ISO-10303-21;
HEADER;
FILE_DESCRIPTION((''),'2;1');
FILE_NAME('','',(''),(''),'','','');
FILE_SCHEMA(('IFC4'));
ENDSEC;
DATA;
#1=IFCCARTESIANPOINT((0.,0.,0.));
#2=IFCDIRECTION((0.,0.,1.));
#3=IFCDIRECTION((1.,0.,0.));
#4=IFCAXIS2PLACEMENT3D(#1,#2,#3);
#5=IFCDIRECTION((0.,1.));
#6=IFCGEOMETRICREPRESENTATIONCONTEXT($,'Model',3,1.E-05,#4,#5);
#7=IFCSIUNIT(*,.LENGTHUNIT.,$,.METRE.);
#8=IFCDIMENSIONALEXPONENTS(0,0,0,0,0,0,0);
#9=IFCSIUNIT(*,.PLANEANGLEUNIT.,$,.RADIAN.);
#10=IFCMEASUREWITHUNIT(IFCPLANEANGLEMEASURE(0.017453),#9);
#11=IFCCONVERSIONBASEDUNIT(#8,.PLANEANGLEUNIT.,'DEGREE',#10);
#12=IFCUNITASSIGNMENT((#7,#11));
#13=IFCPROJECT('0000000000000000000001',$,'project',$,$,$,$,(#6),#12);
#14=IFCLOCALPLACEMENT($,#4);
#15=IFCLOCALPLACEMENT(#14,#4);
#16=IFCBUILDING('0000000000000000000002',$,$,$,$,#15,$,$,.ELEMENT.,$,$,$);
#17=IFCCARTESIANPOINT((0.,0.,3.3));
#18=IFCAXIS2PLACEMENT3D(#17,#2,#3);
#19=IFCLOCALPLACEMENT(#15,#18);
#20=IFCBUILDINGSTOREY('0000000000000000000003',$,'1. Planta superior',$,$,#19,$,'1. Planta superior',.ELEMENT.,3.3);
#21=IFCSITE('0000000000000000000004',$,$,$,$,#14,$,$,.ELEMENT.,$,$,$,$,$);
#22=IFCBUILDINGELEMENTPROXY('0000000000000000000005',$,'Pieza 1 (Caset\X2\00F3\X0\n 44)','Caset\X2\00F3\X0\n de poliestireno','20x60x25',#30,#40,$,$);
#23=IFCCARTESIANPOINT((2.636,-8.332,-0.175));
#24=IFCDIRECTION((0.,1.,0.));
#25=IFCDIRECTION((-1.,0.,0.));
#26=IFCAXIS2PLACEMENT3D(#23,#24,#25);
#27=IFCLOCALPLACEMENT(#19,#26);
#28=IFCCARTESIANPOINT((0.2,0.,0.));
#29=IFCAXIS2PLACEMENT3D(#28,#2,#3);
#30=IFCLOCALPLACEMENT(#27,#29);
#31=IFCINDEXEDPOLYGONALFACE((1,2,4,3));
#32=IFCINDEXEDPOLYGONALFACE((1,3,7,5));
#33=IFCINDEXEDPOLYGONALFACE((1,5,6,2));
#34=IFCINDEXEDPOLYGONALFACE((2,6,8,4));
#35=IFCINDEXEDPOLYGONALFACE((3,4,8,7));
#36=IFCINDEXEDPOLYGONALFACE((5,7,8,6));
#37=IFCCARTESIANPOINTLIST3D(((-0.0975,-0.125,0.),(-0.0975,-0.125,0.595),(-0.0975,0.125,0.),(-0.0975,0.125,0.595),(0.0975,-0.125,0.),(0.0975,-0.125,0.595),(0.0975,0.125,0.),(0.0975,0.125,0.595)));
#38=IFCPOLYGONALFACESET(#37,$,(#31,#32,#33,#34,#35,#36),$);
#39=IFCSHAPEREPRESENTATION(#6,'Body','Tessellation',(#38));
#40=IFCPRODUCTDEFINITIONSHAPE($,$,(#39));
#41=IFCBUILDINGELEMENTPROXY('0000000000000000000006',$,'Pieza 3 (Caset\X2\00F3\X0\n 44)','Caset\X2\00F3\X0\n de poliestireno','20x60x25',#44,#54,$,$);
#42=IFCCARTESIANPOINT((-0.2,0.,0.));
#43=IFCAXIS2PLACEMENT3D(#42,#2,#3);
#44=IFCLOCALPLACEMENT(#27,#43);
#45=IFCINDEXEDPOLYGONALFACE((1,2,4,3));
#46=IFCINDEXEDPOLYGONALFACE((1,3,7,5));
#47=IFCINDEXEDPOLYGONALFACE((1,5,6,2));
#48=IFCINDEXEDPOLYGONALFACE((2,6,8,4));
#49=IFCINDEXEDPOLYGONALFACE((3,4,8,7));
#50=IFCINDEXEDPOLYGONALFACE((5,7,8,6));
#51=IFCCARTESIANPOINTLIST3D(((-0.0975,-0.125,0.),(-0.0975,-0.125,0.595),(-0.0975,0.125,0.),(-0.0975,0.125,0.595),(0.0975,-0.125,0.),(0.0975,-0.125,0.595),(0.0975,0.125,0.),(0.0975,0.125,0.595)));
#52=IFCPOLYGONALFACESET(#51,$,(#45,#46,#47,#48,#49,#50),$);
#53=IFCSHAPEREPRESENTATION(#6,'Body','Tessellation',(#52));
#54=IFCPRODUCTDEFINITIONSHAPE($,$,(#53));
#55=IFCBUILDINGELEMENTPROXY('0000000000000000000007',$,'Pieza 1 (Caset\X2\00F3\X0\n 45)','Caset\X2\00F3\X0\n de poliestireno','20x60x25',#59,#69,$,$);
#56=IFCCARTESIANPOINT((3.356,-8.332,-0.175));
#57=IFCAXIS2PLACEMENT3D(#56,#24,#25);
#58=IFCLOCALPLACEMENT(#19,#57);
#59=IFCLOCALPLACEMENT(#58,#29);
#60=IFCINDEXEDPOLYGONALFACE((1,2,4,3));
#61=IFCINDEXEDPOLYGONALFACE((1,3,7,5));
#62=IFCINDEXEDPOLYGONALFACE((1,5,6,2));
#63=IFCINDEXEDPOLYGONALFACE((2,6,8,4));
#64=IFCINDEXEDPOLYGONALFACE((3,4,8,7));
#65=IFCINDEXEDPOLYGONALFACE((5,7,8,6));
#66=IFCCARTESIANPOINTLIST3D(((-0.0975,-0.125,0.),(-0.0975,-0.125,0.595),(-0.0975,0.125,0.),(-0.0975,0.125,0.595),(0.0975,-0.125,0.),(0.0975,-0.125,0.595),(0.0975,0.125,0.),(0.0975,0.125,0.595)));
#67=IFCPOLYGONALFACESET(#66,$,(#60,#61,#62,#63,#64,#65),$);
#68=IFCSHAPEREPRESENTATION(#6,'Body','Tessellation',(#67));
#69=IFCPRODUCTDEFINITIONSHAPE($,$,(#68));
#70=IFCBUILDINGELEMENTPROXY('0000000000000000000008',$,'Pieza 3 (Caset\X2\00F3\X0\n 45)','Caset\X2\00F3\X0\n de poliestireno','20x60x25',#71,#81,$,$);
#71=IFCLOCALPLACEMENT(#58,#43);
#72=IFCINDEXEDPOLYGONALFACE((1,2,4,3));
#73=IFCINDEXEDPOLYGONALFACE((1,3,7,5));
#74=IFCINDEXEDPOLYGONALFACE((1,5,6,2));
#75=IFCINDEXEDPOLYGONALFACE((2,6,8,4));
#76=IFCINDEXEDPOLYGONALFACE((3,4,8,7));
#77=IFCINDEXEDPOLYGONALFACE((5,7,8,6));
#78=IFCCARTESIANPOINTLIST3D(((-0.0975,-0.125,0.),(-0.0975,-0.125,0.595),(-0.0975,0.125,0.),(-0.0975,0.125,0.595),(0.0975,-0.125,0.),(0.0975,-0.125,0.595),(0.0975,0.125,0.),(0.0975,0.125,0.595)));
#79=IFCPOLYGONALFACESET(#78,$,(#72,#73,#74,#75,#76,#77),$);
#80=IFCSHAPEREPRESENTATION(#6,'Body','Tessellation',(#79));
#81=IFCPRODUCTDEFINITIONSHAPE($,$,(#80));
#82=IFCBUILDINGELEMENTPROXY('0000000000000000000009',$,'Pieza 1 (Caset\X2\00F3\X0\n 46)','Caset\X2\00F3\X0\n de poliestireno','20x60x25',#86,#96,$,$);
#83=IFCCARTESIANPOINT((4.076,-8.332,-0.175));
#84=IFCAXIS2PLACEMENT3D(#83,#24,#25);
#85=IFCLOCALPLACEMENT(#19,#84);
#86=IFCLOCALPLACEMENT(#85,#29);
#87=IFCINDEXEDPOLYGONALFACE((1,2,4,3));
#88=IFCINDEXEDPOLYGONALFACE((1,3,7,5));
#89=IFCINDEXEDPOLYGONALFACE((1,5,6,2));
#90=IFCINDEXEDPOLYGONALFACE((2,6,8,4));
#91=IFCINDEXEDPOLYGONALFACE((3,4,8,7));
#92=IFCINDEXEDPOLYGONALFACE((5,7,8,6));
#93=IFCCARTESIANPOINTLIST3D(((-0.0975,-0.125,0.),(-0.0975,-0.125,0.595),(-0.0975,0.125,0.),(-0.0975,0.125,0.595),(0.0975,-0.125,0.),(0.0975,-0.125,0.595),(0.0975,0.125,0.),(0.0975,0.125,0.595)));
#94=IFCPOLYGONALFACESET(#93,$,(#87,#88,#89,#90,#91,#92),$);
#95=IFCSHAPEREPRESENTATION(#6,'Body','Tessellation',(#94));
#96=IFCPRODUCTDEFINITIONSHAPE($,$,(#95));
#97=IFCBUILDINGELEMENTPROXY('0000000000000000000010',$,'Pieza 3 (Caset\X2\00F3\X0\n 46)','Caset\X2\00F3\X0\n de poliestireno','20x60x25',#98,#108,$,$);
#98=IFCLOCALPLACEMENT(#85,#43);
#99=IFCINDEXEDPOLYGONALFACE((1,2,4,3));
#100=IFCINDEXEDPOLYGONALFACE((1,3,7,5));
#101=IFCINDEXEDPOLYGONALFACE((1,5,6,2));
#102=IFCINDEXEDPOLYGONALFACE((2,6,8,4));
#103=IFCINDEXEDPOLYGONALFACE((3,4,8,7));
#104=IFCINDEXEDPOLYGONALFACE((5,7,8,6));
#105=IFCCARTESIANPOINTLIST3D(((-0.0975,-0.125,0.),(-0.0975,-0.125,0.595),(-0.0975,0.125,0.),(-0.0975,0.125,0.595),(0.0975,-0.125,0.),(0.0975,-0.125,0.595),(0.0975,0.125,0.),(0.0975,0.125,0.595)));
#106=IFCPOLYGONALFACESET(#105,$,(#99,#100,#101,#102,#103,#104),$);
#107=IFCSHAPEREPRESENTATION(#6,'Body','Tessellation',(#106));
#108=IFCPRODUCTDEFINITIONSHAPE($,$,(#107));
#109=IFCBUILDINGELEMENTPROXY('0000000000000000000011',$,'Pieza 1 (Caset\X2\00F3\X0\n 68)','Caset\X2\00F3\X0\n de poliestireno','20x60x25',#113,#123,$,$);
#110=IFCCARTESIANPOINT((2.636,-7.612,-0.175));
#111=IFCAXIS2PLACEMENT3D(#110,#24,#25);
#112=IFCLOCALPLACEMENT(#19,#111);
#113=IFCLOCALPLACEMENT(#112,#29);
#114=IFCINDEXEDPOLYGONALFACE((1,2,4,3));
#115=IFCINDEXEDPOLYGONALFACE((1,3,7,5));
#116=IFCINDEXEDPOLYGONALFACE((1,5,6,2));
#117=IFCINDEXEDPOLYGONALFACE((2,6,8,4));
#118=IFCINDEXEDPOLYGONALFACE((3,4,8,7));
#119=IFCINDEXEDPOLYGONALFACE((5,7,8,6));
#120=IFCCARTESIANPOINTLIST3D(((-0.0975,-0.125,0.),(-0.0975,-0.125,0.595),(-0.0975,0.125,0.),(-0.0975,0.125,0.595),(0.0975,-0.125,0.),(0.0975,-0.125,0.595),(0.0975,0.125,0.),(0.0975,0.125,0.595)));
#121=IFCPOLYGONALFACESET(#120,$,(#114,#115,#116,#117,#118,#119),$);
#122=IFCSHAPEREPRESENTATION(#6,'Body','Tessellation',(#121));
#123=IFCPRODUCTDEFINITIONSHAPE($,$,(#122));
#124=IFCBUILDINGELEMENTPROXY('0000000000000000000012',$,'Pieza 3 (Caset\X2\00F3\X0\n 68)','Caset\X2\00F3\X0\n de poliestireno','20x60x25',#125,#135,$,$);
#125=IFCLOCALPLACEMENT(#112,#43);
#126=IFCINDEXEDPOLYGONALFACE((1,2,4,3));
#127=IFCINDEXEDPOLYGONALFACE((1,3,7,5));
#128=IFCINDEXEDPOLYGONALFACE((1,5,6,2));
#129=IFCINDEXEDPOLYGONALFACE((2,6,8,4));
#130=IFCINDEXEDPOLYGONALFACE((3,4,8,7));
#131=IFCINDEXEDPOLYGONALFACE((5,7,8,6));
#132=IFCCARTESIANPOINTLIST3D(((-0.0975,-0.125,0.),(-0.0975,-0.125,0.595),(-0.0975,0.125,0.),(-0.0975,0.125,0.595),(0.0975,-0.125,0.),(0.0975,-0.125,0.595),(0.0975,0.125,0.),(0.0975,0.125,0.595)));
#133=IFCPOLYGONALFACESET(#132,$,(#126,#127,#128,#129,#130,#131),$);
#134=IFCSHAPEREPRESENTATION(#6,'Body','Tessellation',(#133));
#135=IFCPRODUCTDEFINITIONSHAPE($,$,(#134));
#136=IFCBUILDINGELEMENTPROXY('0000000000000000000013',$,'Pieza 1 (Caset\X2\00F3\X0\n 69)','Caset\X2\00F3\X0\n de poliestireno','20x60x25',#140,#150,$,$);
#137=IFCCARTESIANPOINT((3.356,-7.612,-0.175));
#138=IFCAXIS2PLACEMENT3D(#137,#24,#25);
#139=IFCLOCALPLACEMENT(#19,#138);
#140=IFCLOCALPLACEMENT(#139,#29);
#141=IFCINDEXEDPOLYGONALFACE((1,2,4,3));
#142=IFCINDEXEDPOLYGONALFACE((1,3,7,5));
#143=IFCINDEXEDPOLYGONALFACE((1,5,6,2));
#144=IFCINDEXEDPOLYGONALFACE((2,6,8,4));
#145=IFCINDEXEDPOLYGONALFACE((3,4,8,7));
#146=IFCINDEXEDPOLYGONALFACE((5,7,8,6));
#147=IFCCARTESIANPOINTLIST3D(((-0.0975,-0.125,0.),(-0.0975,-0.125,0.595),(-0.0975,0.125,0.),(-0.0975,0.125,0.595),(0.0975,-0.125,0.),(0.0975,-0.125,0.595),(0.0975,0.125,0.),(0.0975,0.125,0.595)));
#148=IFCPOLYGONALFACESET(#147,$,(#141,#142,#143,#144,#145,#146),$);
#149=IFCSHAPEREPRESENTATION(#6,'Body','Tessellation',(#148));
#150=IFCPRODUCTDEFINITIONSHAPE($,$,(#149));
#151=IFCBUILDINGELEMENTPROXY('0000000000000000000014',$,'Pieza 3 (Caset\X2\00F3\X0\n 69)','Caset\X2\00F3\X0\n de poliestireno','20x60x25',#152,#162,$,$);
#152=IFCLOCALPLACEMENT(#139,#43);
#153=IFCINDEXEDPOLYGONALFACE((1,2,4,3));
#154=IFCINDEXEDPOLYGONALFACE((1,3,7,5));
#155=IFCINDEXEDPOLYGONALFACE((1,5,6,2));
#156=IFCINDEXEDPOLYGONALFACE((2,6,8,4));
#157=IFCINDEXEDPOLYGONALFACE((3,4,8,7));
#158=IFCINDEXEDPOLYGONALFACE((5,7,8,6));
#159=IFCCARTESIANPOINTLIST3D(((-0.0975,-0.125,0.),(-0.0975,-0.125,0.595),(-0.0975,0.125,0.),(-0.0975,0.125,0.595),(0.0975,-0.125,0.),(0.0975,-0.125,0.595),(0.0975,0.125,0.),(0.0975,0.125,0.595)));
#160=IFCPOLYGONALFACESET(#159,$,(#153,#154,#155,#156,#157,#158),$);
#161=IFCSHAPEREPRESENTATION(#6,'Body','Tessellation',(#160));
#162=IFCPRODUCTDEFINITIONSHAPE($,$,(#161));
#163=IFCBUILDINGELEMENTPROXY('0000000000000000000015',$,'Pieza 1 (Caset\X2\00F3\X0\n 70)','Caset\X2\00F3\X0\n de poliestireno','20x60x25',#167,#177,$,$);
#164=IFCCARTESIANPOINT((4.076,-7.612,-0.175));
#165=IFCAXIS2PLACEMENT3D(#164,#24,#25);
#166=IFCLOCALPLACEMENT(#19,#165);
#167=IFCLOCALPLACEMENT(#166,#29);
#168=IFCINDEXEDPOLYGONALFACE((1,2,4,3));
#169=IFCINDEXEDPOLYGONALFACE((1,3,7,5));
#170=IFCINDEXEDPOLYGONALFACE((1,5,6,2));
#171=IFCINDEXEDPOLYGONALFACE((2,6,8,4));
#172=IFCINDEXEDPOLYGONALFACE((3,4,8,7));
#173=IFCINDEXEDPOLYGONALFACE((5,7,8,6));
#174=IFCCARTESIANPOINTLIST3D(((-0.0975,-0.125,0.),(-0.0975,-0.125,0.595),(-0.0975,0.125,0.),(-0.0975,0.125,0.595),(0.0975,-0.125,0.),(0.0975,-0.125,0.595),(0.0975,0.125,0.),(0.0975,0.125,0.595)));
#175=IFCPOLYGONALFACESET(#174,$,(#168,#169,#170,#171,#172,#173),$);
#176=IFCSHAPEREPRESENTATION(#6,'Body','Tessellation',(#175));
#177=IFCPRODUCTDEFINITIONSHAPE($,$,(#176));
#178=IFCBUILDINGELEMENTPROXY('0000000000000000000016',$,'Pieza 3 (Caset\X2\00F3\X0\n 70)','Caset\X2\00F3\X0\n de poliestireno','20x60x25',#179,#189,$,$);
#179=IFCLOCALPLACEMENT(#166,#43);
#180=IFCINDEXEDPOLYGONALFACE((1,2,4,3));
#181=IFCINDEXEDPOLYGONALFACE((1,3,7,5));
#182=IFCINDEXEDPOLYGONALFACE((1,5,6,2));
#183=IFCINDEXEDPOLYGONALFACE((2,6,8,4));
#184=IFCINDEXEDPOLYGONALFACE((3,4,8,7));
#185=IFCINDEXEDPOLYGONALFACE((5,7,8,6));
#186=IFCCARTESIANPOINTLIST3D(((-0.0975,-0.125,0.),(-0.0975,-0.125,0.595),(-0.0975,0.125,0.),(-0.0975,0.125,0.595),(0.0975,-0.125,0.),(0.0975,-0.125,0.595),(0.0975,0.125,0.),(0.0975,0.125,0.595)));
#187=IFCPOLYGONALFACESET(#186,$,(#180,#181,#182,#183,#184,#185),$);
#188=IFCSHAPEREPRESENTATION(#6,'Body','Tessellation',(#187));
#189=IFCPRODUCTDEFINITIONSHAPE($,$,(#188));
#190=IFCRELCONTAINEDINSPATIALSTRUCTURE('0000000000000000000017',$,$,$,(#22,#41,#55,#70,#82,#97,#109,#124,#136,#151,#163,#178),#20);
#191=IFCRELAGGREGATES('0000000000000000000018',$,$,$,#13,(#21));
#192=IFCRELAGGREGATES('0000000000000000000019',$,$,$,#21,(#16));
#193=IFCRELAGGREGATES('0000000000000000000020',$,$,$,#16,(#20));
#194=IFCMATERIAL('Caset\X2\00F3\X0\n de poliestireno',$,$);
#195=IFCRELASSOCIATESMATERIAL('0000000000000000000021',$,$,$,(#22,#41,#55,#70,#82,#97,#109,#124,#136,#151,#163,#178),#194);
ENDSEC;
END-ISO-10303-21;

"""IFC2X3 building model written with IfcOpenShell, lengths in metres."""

from ifc_helpers import new_model, entity, si_unit, converted_unit, direction, frame, origin_with_axes, origin_2d_with_axis, place, context, project, spatial, rectangle, extrude, source, transform, mapped, material, element, save


model = new_model("IFC2X3")

# Units and contexts
model_context = context("Model", 3, precision=1e-05, world=origin_with_axes(), true_north=direction((0.0, 1.0)))
ifc_project = project(units=[si_unit("LENGTHUNIT", "METRE"), converted_unit("PLANEANGLEUNIT", "DEGREE", entity("IfcPlaneAngleMeasure", 0.017453), si_unit("PLANEANGLEUNIT", "RADIAN"), dimensions=[0, 0, 0, 0, 0, 0, 0])], contexts=[model_context])

# Site, building, storey
site_placement = place(None, origin_with_axes())
site = spatial("IfcSite", under=ifc_project, at=site_placement, CompositionType="ELEMENT")
building_placement = place(site_placement, origin_with_axes())
building = spatial("IfcBuilding", under=site, at=building_placement, CompositionType="ELEMENT")
storey_placement = place(building_placement, frame((0.0, 0.0, 3.3), z_axis=(0.0, 0.0, 1.0), x_axis=(1.0, 0.0, 0.0)))
storey = spatial("IfcBuildingStorey", under=building, at=storey_placement, Name="1. Planta superior", LongName="1. Planta superior", CompositionType="ELEMENT", Elevation=3.3)

# Building element proxies
ifc_material = material(Name="Casetón de poliestireno")
shared_shape = source(origin_with_axes(), model_context, "Body", "SweptSolid", [
    extrude(rectangle(XDim=0.195, YDim=0.25, at=origin_2d_with_axis()), origin_with_axes(), (0.0, 0.0, 1.0), 0.595),
])
placement_1 = place(storey_placement, frame((2.636, -8.332, -0.175), z_axis=(0.0, 1.0, 0.0), x_axis=(-1.0, 0.0, 0.0)))
for number, where, z_axis, x_axis, name in (
    (1, (0.2, 0.0, 0.0), (0.0, 0.0, 1.0), (1.0, 0.0, 0.0), "Pieza 1 (Casetón 44)"),
    (2, (-0.2, 0.0, 0.0), (0.0, 0.0, 1.0), (1.0, 0.0, 0.0), "Pieza 3 (Casetón 44)"),
):
    element("IfcBuildingElementProxy", number, at=place(placement_1, frame(where, z_axis=z_axis, x_axis=x_axis)), inside=storey, material=ifc_material, Name=name, Description="Casetón de poliestireno", ObjectType="20x60x25", context=model_context, shape_type="MappedRepresentation", body=[
        mapped(shared_shape, transform((0.0, 0.0, 0.0), x_axis=(1.0, 0.0, 0.0), y_axis=(0.0, 1.0, 0.0), z_axis=(0.0, 0.0, 1.0))),
    ])
placement_2 = place(storey_placement, frame((3.356, -8.332, -0.175), z_axis=(0.0, 1.0, 0.0), x_axis=(-1.0, 0.0, 0.0)))
for number, where, z_axis, x_axis, name in (
    (3, (0.2, 0.0, 0.0), (0.0, 0.0, 1.0), (1.0, 0.0, 0.0), "Pieza 1 (Casetón 45)"),
    (4, (-0.2, 0.0, 0.0), (0.0, 0.0, 1.0), (1.0, 0.0, 0.0), "Pieza 3 (Casetón 45)"),
):
    element("IfcBuildingElementProxy", number, at=place(placement_2, frame(where, z_axis=z_axis, x_axis=x_axis)), inside=storey, material=ifc_material, Name=name, Description="Casetón de poliestireno", ObjectType="20x60x25", context=model_context, shape_type="MappedRepresentation", body=[
        mapped(shared_shape, transform((0.0, 0.0, 0.0), x_axis=(1.0, 0.0, 0.0), y_axis=(0.0, 1.0, 0.0), z_axis=(0.0, 0.0, 1.0))),
    ])
placement_3 = place(storey_placement, frame((4.076, -8.332, -0.175), z_axis=(0.0, 1.0, 0.0), x_axis=(-1.0, 0.0, 0.0)))
for number, where, z_axis, x_axis, name in (
    (5, (0.2, 0.0, 0.0), (0.0, 0.0, 1.0), (1.0, 0.0, 0.0), "Pieza 1 (Casetón 46)"),
    (6, (-0.2, 0.0, 0.0), (0.0, 0.0, 1.0), (1.0, 0.0, 0.0), "Pieza 3 (Casetón 46)"),
):
    element("IfcBuildingElementProxy", number, at=place(placement_3, frame(where, z_axis=z_axis, x_axis=x_axis)), inside=storey, material=ifc_material, Name=name, Description="Casetón de poliestireno", ObjectType="20x60x25", context=model_context, shape_type="MappedRepresentation", body=[
        mapped(shared_shape, transform((0.0, 0.0, 0.0), x_axis=(1.0, 0.0, 0.0), y_axis=(0.0, 1.0, 0.0), z_axis=(0.0, 0.0, 1.0))),
    ])
placement_4 = place(storey_placement, frame((2.636, -7.612, -0.175), z_axis=(0.0, 1.0, 0.0), x_axis=(-1.0, 0.0, 0.0)))
for number, where, z_axis, x_axis, name in (
    (7, (0.2, 0.0, 0.0), (0.0, 0.0, 1.0), (1.0, 0.0, 0.0), "Pieza 1 (Casetón 68)"),
    (8, (-0.2, 0.0, 0.0), (0.0, 0.0, 1.0), (1.0, 0.0, 0.0), "Pieza 3 (Casetón 68)"),
):
    element("IfcBuildingElementProxy", number, at=place(placement_4, frame(where, z_axis=z_axis, x_axis=x_axis)), inside=storey, material=ifc_material, Name=name, Description="Casetón de poliestireno", ObjectType="20x60x25", context=model_context, shape_type="MappedRepresentation", body=[
        mapped(shared_shape, transform((0.0, 0.0, 0.0), x_axis=(1.0, 0.0, 0.0), y_axis=(0.0, 1.0, 0.0), z_axis=(0.0, 0.0, 1.0))),
    ])
placement_5 = place(storey_placement, frame((3.356, -7.612, -0.175), z_axis=(0.0, 1.0, 0.0), x_axis=(-1.0, 0.0, 0.0)))
for number, where, z_axis, x_axis, name in (
    (9, (0.2, 0.0, 0.0), (0.0, 0.0, 1.0), (1.0, 0.0, 0.0), "Pieza 1 (Casetón 69)"),
    (10, (-0.2, 0.0, 0.0), (0.0, 0.0, 1.0), (1.0, 0.0, 0.0), "Pieza 3 (Casetón 69)"),
):
    element("IfcBuildingElementProxy", number, at=place(placement_5, frame(where, z_axis=z_axis, x_axis=x_axis)), inside=storey, material=ifc_material, Name=name, Description="Casetón de poliestireno", ObjectType="20x60x25", context=model_context, shape_type="MappedRepresentation", body=[
        mapped(shared_shape, transform((0.0, 0.0, 0.0), x_axis=(1.0, 0.0, 0.0), y_axis=(0.0, 1.0, 0.0), z_axis=(0.0, 0.0, 1.0))),
    ])
placement_6 = place(storey_placement, frame((4.076, -7.612, -0.175), z_axis=(0.0, 1.0, 0.0), x_axis=(-1.0, 0.0, 0.0)))
for number, where, z_axis, x_axis, name in (
    (11, (0.2, 0.0, 0.0), (0.0, 0.0, 1.0), (1.0, 0.0, 0.0), "Pieza 1 (Casetón 70)"),
    (12, (-0.2, 0.0, 0.0), (0.0, 0.0, 1.0), (1.0, 0.0, 0.0), "Pieza 3 (Casetón 70)"),
):
    element("IfcBuildingElementProxy", number, at=place(placement_6, frame(where, z_axis=z_axis, x_axis=x_axis)), inside=storey, material=ifc_material, Name=name, Description="Casetón de poliestireno", ObjectType="20x60x25", context=model_context, shape_type="MappedRepresentation", body=[
        mapped(shared_shape, transform((0.0, 0.0, 0.0), x_axis=(1.0, 0.0, 0.0), y_axis=(0.0, 1.0, 0.0), z_axis=(0.0, 0.0, 1.0))),
    ])

save(model, "model.ifc")
